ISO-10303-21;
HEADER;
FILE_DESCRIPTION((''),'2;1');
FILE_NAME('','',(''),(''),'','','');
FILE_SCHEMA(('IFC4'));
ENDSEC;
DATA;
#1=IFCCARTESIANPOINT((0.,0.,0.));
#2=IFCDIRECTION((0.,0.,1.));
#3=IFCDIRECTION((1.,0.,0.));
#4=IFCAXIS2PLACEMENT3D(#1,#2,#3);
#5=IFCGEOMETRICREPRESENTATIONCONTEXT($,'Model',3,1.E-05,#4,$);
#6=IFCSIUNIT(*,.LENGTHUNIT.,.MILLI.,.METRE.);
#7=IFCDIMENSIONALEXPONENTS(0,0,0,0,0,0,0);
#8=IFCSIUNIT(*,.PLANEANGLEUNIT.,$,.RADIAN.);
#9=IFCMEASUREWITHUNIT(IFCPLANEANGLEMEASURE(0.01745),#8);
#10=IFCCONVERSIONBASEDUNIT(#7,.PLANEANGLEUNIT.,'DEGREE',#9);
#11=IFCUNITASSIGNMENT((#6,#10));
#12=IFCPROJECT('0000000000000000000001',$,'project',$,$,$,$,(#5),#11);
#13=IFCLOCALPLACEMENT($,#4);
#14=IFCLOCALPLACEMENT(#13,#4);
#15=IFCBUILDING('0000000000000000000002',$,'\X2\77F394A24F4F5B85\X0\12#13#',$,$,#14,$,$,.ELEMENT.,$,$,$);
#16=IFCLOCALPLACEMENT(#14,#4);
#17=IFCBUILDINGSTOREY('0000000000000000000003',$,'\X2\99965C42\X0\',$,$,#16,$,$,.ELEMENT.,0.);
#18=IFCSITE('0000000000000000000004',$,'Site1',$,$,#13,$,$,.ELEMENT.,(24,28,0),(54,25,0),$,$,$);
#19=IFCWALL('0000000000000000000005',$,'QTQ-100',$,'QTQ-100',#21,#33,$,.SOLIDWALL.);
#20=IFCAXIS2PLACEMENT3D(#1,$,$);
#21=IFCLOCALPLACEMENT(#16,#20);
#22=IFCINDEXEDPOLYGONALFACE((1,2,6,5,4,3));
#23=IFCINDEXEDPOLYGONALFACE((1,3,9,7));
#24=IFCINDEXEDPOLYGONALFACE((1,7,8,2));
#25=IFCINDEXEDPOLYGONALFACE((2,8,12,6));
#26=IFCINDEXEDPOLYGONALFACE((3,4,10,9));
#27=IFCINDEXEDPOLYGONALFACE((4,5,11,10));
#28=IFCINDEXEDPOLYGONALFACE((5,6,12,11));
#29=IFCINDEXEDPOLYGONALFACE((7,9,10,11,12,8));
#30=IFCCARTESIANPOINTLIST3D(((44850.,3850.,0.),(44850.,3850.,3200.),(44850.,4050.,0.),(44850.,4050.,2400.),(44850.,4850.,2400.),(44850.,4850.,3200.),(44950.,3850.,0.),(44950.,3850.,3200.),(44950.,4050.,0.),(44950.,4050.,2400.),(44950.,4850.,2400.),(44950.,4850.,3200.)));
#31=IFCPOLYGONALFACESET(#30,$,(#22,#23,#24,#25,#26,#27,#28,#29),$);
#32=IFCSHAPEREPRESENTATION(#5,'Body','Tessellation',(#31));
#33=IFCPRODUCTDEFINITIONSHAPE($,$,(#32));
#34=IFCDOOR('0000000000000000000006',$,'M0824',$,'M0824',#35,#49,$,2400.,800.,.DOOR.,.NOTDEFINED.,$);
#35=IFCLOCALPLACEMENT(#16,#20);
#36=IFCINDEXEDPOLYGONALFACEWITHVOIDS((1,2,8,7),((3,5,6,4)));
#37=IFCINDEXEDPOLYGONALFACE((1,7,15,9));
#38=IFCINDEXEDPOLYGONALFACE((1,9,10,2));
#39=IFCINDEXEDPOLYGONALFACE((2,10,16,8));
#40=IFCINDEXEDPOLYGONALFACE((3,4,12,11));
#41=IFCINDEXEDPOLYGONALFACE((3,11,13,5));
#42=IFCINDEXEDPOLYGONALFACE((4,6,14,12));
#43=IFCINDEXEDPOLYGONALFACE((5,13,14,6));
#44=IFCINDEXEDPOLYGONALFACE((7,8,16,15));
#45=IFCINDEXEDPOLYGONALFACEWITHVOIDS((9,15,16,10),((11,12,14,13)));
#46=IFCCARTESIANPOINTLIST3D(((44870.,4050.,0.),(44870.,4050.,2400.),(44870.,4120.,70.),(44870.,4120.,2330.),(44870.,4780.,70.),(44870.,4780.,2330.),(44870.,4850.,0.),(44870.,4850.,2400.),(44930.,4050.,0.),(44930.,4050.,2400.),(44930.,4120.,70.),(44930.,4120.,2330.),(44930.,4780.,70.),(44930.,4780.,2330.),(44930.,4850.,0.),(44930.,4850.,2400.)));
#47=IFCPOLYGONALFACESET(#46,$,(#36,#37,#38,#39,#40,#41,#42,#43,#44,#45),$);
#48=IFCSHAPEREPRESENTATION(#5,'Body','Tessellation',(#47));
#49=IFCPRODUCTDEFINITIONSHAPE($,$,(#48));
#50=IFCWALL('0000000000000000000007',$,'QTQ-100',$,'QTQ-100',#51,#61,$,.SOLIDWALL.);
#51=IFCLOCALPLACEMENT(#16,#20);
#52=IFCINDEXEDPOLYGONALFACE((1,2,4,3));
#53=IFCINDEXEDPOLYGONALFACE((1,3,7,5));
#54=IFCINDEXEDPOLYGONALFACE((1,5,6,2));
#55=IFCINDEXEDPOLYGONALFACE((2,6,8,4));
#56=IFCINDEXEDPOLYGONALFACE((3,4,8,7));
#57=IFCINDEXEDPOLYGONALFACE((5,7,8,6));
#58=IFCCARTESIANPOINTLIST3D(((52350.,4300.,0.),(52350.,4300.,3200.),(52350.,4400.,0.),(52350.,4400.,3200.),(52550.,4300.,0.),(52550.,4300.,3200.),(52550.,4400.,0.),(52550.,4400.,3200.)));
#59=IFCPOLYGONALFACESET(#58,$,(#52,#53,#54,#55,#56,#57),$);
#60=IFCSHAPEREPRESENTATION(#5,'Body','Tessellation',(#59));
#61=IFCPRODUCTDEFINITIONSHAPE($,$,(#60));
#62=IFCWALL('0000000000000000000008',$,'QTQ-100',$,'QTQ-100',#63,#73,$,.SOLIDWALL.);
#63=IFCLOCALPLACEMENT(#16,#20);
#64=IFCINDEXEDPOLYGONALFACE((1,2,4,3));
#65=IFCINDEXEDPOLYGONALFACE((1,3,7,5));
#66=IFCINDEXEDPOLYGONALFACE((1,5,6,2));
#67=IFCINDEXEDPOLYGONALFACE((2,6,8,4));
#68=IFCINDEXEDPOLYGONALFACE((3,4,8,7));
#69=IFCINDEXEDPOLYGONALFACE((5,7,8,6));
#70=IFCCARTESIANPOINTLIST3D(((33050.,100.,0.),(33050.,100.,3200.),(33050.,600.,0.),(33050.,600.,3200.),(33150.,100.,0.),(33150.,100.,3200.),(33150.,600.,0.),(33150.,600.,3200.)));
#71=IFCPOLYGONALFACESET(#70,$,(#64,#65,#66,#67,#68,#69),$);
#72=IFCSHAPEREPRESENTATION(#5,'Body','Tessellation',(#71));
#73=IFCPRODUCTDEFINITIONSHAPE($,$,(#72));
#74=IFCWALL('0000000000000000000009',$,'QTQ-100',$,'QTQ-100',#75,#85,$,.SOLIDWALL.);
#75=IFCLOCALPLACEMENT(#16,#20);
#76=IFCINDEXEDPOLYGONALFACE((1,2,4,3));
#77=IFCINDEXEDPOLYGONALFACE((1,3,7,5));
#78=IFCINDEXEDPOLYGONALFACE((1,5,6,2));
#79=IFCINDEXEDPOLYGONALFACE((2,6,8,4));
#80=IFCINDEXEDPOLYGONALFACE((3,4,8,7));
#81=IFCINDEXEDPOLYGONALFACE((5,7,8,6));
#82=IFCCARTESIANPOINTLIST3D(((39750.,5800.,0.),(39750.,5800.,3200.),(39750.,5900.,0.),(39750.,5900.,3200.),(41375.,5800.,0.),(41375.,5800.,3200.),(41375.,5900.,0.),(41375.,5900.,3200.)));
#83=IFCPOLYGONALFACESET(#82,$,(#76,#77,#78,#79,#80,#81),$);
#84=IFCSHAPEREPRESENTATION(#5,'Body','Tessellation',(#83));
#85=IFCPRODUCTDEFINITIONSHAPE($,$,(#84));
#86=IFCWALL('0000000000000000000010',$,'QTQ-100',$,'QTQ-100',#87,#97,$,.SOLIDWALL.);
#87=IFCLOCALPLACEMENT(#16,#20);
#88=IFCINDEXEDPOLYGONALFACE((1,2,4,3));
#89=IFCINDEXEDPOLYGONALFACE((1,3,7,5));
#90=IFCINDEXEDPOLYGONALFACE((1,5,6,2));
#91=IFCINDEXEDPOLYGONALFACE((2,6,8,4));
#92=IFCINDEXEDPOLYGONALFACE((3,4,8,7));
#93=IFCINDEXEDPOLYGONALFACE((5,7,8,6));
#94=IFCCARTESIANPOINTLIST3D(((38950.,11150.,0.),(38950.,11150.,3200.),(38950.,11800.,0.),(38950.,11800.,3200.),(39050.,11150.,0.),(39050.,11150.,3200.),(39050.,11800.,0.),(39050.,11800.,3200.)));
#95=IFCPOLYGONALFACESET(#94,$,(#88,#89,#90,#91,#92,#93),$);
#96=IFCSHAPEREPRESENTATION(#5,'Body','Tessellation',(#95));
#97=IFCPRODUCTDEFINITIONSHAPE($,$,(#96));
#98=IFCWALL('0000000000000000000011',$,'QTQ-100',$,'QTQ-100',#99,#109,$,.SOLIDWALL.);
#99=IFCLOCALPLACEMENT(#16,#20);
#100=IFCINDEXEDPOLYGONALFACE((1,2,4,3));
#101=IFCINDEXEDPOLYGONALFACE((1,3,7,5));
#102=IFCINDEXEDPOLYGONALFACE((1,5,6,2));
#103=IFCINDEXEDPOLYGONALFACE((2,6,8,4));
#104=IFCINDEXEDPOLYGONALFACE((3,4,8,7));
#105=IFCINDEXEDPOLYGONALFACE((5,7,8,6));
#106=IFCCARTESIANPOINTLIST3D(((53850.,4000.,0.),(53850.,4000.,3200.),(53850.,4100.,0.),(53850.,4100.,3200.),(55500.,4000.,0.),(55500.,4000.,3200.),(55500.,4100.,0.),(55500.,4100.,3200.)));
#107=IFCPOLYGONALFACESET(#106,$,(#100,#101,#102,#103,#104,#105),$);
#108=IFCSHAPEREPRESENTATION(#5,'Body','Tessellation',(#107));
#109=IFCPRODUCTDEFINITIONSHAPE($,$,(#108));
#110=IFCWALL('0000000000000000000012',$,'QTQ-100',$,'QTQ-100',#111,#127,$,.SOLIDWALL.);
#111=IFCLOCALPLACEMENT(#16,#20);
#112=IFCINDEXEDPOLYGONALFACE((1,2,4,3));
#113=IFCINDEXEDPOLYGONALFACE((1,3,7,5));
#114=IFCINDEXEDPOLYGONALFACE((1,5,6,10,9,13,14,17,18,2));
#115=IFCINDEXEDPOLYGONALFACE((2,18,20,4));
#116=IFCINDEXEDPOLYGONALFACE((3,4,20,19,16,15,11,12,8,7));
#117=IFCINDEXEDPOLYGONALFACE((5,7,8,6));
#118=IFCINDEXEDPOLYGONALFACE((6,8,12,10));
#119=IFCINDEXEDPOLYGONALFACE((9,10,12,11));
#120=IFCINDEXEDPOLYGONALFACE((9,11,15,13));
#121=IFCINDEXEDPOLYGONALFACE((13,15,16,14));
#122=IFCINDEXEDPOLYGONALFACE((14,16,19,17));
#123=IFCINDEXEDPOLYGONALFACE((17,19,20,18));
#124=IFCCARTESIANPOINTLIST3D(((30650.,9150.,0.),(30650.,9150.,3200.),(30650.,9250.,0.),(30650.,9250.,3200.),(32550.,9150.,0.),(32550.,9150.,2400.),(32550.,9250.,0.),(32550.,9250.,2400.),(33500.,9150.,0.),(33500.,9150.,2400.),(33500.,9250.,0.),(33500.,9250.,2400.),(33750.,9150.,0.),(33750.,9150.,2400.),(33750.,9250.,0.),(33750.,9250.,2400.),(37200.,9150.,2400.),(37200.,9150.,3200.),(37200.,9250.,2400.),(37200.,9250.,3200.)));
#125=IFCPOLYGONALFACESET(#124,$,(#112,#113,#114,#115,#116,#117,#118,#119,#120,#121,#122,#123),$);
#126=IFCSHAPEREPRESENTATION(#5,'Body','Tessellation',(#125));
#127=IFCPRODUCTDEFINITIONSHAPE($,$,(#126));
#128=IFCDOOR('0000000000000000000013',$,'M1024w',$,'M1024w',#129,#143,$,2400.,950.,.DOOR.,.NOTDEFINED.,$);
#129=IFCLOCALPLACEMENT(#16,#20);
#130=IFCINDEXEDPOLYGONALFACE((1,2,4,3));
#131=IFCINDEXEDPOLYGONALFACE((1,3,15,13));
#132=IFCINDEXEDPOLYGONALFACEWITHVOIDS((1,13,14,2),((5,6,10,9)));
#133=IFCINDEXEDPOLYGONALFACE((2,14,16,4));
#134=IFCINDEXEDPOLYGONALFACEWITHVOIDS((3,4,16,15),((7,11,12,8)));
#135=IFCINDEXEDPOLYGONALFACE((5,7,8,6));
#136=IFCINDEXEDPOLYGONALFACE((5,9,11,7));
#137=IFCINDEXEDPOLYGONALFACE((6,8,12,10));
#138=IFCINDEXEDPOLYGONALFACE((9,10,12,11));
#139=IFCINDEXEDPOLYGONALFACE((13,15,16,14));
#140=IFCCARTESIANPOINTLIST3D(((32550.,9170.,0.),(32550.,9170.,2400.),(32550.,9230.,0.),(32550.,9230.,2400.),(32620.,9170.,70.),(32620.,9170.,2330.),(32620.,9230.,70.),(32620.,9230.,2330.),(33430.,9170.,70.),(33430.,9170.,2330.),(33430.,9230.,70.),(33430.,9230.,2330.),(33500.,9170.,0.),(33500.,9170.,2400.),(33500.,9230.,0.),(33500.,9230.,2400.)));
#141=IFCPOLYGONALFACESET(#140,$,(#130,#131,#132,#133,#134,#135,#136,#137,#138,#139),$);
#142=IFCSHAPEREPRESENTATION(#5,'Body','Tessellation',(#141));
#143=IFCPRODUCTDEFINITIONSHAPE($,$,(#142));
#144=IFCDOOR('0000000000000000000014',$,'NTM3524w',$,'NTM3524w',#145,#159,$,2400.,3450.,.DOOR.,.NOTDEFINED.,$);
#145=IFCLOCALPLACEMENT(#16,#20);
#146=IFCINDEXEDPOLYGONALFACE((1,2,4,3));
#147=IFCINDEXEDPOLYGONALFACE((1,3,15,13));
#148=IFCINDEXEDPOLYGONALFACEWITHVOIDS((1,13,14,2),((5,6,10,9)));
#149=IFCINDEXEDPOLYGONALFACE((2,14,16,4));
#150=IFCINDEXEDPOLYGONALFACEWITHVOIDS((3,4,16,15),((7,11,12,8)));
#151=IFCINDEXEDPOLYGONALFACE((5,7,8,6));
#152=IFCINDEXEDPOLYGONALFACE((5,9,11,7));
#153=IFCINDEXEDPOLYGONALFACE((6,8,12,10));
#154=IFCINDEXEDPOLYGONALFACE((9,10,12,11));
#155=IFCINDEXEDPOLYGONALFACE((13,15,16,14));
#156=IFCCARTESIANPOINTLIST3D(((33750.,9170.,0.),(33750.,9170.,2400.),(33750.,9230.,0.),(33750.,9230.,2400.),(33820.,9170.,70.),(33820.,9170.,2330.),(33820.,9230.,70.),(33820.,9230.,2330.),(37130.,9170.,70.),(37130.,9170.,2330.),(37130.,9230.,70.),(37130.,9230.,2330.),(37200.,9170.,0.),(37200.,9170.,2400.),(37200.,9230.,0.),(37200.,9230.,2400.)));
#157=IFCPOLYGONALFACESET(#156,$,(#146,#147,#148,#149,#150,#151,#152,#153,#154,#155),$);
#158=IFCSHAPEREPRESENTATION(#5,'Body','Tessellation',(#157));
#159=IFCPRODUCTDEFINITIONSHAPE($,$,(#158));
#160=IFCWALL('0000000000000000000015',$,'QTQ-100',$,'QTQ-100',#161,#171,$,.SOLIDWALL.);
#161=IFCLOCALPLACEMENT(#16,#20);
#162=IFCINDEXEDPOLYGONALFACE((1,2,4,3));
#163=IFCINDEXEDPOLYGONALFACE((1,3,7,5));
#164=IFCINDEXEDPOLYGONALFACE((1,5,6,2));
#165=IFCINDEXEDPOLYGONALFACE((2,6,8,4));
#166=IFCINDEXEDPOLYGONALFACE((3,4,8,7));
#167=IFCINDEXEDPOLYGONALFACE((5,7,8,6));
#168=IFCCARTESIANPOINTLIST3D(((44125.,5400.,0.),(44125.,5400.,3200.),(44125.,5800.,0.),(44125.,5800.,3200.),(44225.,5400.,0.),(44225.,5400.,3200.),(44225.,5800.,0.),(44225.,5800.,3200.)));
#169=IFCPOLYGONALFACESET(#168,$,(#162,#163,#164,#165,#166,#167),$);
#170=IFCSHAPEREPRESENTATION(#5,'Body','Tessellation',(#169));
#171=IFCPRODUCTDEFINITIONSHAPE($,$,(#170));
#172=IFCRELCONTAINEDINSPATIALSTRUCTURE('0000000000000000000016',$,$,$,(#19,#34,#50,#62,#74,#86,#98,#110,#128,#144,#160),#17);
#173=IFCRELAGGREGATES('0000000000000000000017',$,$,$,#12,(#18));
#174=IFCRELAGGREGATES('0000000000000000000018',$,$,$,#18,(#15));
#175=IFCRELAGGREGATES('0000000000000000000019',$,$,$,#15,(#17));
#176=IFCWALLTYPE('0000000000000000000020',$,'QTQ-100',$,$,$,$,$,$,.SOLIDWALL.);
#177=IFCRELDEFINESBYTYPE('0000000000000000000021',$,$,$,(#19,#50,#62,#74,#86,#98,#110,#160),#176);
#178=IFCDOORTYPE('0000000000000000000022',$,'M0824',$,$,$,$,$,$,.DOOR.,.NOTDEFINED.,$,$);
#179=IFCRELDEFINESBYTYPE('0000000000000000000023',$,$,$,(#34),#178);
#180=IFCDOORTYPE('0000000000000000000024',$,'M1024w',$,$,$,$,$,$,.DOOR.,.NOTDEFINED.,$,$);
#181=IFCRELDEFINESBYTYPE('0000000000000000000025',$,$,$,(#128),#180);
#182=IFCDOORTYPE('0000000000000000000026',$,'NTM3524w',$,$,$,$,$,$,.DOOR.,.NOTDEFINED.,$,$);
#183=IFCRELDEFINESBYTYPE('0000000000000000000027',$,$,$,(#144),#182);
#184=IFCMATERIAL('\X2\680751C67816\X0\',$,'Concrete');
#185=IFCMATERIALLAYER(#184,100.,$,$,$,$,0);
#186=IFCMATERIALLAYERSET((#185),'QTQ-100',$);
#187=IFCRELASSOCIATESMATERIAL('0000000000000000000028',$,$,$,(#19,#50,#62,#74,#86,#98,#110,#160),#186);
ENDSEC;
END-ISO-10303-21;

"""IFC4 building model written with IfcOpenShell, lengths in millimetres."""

from ifc_helpers import new_model, entity, si_unit, converted_unit, frame, origin_with_axes, place, context, project, spatial, polyline, outline, extrude, material, layer, layer_set, type_object, element, fill, save


model = new_model("IFC4")

# Units and contexts
model_context = context("Model", 3, precision=1e-05, world=origin_with_axes())
ifc_project = project(units=[si_unit("LENGTHUNIT", "METRE", prefix="MILLI"), converted_unit("PLANEANGLEUNIT", "DEGREE", entity("IfcPlaneAngleMeasure", 0.01745), si_unit("PLANEANGLEUNIT", "RADIAN"), dimensions=[0, 0, 0, 0, 0, 0, 0])], contexts=[model_context])

# Site, building, storey
site_placement = place(None, origin_with_axes())
site = spatial("IfcSite", under=ifc_project, at=site_placement, Name="Site1", CompositionType="ELEMENT", RefLatitude=(24, 28, 0), RefLongitude=(54, 25, 0))
building_placement = place(site_placement, origin_with_axes())
building = spatial("IfcBuilding", under=site, at=building_placement, Name="石钢住宅12#13#", CompositionType="ELEMENT")
storey_placement = place(building_placement, origin_with_axes())
storey = spatial("IfcBuildingStorey", under=building, at=storey_placement, Name="首层", CompositionType="ELEMENT", Elevation=0.0)

# Wall, opening, door
ifc_material = material(Name="标准砖", Category="Concrete")
ifc_layer = layer(ifc_material, 100.0, Priority=0)
ifc_layer_set = layer_set([ifc_layer], Name="QTQ-100")
wall_type = type_object("IfcWallType", Name="QTQ-100", PredefinedType="SOLIDWALL")
wall_1_placement = place(storey_placement, origin_with_axes())
wall_1 = element("IfcWall", 1, at=wall_1_placement, inside=storey, type_object=wall_type, material=ifc_layer_set, Name="QTQ-100", ObjectType="QTQ-100", PredefinedType="SOLIDWALL", context=model_context, shape_type="SweptSolid", body=[
    extrude(outline(polyline([(0.0, 0.0), (3200.0, 0.0), (3200.0, 1000.0), (0.0, 1000.0), (0.0, 0.0)])), frame((44850.0, 3850.0, 3200.0), z_axis=(1.0, 0.0, 0.0), x_axis=(0.0, 0.0, -1.0)), (0.0, 0.0, 1.0), 100.0),
])
opening_1_placement = place(storey_placement, origin_with_axes())
opening_1 = element("IfcOpeningElement", 2, at=opening_1_placement, cuts=wall_1, PredefinedType="OPENING", context=model_context, shape_type="SweptSolid", body=[
    extrude(outline(polyline([(0.0, 0.0), (800.0, 0.0), (800.0, 2400.0), (0.0, 2400.0), (0.0, 0.0)])), frame((43850.0, 4050.0, 0.0), z_axis=(1.0, 0.0, 0.0), x_axis=(0.0, 1.0, 0.0)), (0.0, 0.0, 1.0), 2100.0),
])
door_type_1 = type_object("IfcDoorType", Name="M0824", OperationType="NOTDEFINED", PredefinedType="DOOR")
door_1_placement = place(storey_placement, origin_with_axes())
door_1 = element("IfcDoor", 3, at=door_1_placement, inside=storey, type_object=door_type_1, Name="M0824", ObjectType="M0824", OperationType="NOTDEFINED", OverallHeight=2400.0, OverallWidth=800.0, PredefinedType="DOOR", context=model_context, shape_type="SweptSolid", body=[
    extrude(outline(polyline([(-400.0, -1200.0), (400.0, -1200.0), (400.0, 1200.0), (-400.0, 1200.0), (-400.0, -1200.0)]), holes=[polyline([(-330.0, -1130.0), (-330.0, 1130.0), (330.0, 1130.0), (330.0, -1130.0), (-330.0, -1130.0)])]), frame((44870.0, 4450.0, 1200.0), z_axis=(1.0, 0.0, 0.0), x_axis=(0.0, 1.0, 0.0)), (0.0, 0.0, 1.0), 60.0),
])
fill(opening_1, door_1)

# Walls
wall_2_placement = place(storey_placement, origin_with_axes())
element("IfcWall", 4, at=wall_2_placement, inside=storey, type_object=wall_type, material=ifc_layer_set, Name="QTQ-100", ObjectType="QTQ-100", PredefinedType="SOLIDWALL", context=model_context, shape_type="SweptSolid", body=[
    extrude(outline(polyline([(0.0, 0.0), (3200.0, 0.0), (3200.0, 200.0), (0.0, 200.0), (0.0, 0.0)])), frame((52550.0, 4300.0, 3200.0), z_axis=(0.0, 1.0, 0.0), x_axis=(0.0, 0.0, -1.0)), (0.0, 0.0, 1.0), 100.0),
])
wall_3_placement = place(storey_placement, origin_with_axes())
element("IfcWall", 5, at=wall_3_placement, inside=storey, type_object=wall_type, material=ifc_layer_set, Name="QTQ-100", ObjectType="QTQ-100", PredefinedType="SOLIDWALL", context=model_context, shape_type="SweptSolid", body=[
    extrude(outline(polyline([(0.0, 0.0), (3200.0, 0.0), (3200.0, 500.0), (0.0, 500.0), (0.0, 0.0)])), frame((33050.0, 100.0, 3200.0), z_axis=(1.0, 0.0, 0.0), x_axis=(0.0, 0.0, -1.0)), (0.0, 0.0, 1.0), 100.0),
])
wall_4_placement = place(storey_placement, origin_with_axes())
element("IfcWall", 6, at=wall_4_placement, inside=storey, type_object=wall_type, material=ifc_layer_set, Name="QTQ-100", ObjectType="QTQ-100", PredefinedType="SOLIDWALL", context=model_context, shape_type="SweptSolid", body=[
    extrude(outline(polyline([(0.0, 0.0), (3200.0, 0.0), (3200.0, 1625.0), (0.0, 1625.0), (0.0, 0.0)])), frame((41375.0, 5800.0, 3200.0), z_axis=(0.0, 1.0, 0.0), x_axis=(0.0, 0.0, -1.0)), (0.0, 0.0, 1.0), 100.0),
])
wall_5_placement = place(storey_placement, origin_with_axes())
element("IfcWall", 7, at=wall_5_placement, inside=storey, type_object=wall_type, material=ifc_layer_set, Name="QTQ-100", ObjectType="QTQ-100", PredefinedType="SOLIDWALL", context=model_context, shape_type="SweptSolid", body=[
    extrude(outline(polyline([(0.0, 0.0), (3200.0, 0.0), (3200.0, 650.0), (0.0, 650.0), (0.0, 0.0)])), frame((38950.0, 11150.0, 3200.0), z_axis=(1.0, 0.0, 0.0), x_axis=(0.0, 0.0, -1.0)), (0.0, 0.0, 1.0), 100.0),
])
wall_6_placement = place(storey_placement, origin_with_axes())
element("IfcWall", 8, at=wall_6_placement, inside=storey, type_object=wall_type, material=ifc_layer_set, Name="QTQ-100", ObjectType="QTQ-100", PredefinedType="SOLIDWALL", context=model_context, shape_type="SweptSolid", body=[
    extrude(outline(polyline([(0.0, 0.0), (3200.0, 0.0), (3200.0, 1650.0), (0.0, 1650.0), (0.0, 0.0)])), frame((55500.0, 4000.0, 3200.0), z_axis=(0.0, 1.0, 0.0), x_axis=(0.0, 0.0, -1.0)), (0.0, 0.0, 1.0), 100.0),
])

# Wall, openings, doors
wall_7_placement = place(storey_placement, origin_with_axes())
wall_7 = element("IfcWall", 9, at=wall_7_placement, inside=storey, type_object=wall_type, material=ifc_layer_set, Name="QTQ-100", ObjectType="QTQ-100", PredefinedType="SOLIDWALL", context=model_context, shape_type="SweptSolid", body=[
    extrude(outline(polyline([(0.0, 0.0), (3200.0, 0.0), (3200.0, 6550.0), (0.0, 6550.0), (0.0, 0.0)])), frame((37200.0, 9150.0, 3200.0), z_axis=(0.0, 1.0, 0.0), x_axis=(0.0, 0.0, -1.0)), (0.0, 0.0, 1.0), 100.0),
])
opening_2_placement = place(storey_placement, origin_with_axes())
opening_2 = element("IfcOpeningElement", 10, at=opening_2_placement, cuts=wall_7, PredefinedType="OPENING", context=model_context, shape_type="SweptSolid", body=[
    extrude(outline(polyline([(0.0, 0.0), (950.0, 0.0), (950.0, 2400.0), (0.0, 2400.0), (0.0, 0.0)])), frame((33500.0, 8150.0, 0.0), z_axis=(0.0, 1.0, 0.0), x_axis=(-1.0, 0.0, 0.0)), (0.0, 0.0, 1.0), 2100.0),
])
opening_3_placement = place(storey_placement, origin_with_axes())
opening_3 = element("IfcOpeningElement", 11, at=opening_3_placement, cuts=wall_7, PredefinedType="OPENING", context=model_context, shape_type="SweptSolid", body=[
    extrude(outline(polyline([(0.0, 0.0), (3450.0, 0.0), (3450.0, 2400.0), (0.0, 2400.0), (0.0, 0.0)])), frame((37200.0, 8150.0, 0.0), z_axis=(0.0, 1.0, 0.0), x_axis=(-1.0, 0.0, 0.0)), (0.0, 0.0, 1.0), 2100.0),
])
door_type_2 = type_object("IfcDoorType", Name="M1024w", OperationType="NOTDEFINED", PredefinedType="DOOR")
door_2_placement = place(storey_placement, origin_with_axes())
door_2 = element("IfcDoor", 12, at=door_2_placement, inside=storey, type_object=door_type_2, Name="M1024w", ObjectType="M1024w", OperationType="NOTDEFINED", OverallHeight=2400.0, OverallWidth=950.0, PredefinedType="DOOR", context=model_context, shape_type="SweptSolid", body=[
    extrude(outline(polyline([(-475.0, -1200.0), (475.0, -1200.0), (475.0, 1200.0), (-475.0, 1200.0), (-475.0, -1200.0)]), holes=[polyline([(-405.0, -1130.0), (-405.0, 1130.0), (405.0, 1130.0), (405.0, -1130.0), (-405.0, -1130.0)])]), frame((33025.0, 9170.0, 1200.0), z_axis=(0.0, 1.0, 0.0), x_axis=(-1.0, 0.0, 0.0)), (0.0, 0.0, 1.0), 60.0),
])
fill(opening_2, door_2)
door_type_3 = type_object("IfcDoorType", Name="NTM3524w", OperationType="NOTDEFINED", PredefinedType="DOOR")
door_3_placement = place(storey_placement, origin_with_axes())
door_3 = element("IfcDoor", 13, at=door_3_placement, inside=storey, type_object=door_type_3, Name="NTM3524w", ObjectType="NTM3524w", OperationType="NOTDEFINED", OverallHeight=2400.0, OverallWidth=3450.0, PredefinedType="DOOR", context=model_context, shape_type="SweptSolid", body=[
    extrude(outline(polyline([(-1725.0, -1200.0), (1725.0, -1200.0), (1725.0, 1200.0), (-1725.0, 1200.0), (-1725.0, -1200.0)]), holes=[polyline([(-1655.0, -1130.0), (-1655.0, 1130.0), (1655.0, 1130.0), (1655.0, -1130.0), (-1655.0, -1130.0)])]), frame((35475.0, 9170.0, 1200.0), z_axis=(0.0, 1.0, 0.0), x_axis=(-1.0, 0.0, 0.0)), (0.0, 0.0, 1.0), 60.0),
])
fill(opening_3, door_3)

# Wall
wall_8_placement = place(storey_placement, origin_with_axes())
element("IfcWall", 14, at=wall_8_placement, inside=storey, type_object=wall_type, material=ifc_layer_set, Name="QTQ-100", ObjectType="QTQ-100", PredefinedType="SOLIDWALL", context=model_context, shape_type="SweptSolid", body=[
    extrude(outline(polyline([(0.0, 0.0), (3200.0, 0.0), (3200.0, 400.0), (0.0, 400.0), (0.0, 0.0)])), frame((44225.0, 5800.0, 3200.0), z_axis=(-1.0, 0.0, 0.0), x_axis=(0.0, 0.0, -1.0)), (0.0, 0.0, 1.0), 100.0),
])

save(model, "model.ifc")
